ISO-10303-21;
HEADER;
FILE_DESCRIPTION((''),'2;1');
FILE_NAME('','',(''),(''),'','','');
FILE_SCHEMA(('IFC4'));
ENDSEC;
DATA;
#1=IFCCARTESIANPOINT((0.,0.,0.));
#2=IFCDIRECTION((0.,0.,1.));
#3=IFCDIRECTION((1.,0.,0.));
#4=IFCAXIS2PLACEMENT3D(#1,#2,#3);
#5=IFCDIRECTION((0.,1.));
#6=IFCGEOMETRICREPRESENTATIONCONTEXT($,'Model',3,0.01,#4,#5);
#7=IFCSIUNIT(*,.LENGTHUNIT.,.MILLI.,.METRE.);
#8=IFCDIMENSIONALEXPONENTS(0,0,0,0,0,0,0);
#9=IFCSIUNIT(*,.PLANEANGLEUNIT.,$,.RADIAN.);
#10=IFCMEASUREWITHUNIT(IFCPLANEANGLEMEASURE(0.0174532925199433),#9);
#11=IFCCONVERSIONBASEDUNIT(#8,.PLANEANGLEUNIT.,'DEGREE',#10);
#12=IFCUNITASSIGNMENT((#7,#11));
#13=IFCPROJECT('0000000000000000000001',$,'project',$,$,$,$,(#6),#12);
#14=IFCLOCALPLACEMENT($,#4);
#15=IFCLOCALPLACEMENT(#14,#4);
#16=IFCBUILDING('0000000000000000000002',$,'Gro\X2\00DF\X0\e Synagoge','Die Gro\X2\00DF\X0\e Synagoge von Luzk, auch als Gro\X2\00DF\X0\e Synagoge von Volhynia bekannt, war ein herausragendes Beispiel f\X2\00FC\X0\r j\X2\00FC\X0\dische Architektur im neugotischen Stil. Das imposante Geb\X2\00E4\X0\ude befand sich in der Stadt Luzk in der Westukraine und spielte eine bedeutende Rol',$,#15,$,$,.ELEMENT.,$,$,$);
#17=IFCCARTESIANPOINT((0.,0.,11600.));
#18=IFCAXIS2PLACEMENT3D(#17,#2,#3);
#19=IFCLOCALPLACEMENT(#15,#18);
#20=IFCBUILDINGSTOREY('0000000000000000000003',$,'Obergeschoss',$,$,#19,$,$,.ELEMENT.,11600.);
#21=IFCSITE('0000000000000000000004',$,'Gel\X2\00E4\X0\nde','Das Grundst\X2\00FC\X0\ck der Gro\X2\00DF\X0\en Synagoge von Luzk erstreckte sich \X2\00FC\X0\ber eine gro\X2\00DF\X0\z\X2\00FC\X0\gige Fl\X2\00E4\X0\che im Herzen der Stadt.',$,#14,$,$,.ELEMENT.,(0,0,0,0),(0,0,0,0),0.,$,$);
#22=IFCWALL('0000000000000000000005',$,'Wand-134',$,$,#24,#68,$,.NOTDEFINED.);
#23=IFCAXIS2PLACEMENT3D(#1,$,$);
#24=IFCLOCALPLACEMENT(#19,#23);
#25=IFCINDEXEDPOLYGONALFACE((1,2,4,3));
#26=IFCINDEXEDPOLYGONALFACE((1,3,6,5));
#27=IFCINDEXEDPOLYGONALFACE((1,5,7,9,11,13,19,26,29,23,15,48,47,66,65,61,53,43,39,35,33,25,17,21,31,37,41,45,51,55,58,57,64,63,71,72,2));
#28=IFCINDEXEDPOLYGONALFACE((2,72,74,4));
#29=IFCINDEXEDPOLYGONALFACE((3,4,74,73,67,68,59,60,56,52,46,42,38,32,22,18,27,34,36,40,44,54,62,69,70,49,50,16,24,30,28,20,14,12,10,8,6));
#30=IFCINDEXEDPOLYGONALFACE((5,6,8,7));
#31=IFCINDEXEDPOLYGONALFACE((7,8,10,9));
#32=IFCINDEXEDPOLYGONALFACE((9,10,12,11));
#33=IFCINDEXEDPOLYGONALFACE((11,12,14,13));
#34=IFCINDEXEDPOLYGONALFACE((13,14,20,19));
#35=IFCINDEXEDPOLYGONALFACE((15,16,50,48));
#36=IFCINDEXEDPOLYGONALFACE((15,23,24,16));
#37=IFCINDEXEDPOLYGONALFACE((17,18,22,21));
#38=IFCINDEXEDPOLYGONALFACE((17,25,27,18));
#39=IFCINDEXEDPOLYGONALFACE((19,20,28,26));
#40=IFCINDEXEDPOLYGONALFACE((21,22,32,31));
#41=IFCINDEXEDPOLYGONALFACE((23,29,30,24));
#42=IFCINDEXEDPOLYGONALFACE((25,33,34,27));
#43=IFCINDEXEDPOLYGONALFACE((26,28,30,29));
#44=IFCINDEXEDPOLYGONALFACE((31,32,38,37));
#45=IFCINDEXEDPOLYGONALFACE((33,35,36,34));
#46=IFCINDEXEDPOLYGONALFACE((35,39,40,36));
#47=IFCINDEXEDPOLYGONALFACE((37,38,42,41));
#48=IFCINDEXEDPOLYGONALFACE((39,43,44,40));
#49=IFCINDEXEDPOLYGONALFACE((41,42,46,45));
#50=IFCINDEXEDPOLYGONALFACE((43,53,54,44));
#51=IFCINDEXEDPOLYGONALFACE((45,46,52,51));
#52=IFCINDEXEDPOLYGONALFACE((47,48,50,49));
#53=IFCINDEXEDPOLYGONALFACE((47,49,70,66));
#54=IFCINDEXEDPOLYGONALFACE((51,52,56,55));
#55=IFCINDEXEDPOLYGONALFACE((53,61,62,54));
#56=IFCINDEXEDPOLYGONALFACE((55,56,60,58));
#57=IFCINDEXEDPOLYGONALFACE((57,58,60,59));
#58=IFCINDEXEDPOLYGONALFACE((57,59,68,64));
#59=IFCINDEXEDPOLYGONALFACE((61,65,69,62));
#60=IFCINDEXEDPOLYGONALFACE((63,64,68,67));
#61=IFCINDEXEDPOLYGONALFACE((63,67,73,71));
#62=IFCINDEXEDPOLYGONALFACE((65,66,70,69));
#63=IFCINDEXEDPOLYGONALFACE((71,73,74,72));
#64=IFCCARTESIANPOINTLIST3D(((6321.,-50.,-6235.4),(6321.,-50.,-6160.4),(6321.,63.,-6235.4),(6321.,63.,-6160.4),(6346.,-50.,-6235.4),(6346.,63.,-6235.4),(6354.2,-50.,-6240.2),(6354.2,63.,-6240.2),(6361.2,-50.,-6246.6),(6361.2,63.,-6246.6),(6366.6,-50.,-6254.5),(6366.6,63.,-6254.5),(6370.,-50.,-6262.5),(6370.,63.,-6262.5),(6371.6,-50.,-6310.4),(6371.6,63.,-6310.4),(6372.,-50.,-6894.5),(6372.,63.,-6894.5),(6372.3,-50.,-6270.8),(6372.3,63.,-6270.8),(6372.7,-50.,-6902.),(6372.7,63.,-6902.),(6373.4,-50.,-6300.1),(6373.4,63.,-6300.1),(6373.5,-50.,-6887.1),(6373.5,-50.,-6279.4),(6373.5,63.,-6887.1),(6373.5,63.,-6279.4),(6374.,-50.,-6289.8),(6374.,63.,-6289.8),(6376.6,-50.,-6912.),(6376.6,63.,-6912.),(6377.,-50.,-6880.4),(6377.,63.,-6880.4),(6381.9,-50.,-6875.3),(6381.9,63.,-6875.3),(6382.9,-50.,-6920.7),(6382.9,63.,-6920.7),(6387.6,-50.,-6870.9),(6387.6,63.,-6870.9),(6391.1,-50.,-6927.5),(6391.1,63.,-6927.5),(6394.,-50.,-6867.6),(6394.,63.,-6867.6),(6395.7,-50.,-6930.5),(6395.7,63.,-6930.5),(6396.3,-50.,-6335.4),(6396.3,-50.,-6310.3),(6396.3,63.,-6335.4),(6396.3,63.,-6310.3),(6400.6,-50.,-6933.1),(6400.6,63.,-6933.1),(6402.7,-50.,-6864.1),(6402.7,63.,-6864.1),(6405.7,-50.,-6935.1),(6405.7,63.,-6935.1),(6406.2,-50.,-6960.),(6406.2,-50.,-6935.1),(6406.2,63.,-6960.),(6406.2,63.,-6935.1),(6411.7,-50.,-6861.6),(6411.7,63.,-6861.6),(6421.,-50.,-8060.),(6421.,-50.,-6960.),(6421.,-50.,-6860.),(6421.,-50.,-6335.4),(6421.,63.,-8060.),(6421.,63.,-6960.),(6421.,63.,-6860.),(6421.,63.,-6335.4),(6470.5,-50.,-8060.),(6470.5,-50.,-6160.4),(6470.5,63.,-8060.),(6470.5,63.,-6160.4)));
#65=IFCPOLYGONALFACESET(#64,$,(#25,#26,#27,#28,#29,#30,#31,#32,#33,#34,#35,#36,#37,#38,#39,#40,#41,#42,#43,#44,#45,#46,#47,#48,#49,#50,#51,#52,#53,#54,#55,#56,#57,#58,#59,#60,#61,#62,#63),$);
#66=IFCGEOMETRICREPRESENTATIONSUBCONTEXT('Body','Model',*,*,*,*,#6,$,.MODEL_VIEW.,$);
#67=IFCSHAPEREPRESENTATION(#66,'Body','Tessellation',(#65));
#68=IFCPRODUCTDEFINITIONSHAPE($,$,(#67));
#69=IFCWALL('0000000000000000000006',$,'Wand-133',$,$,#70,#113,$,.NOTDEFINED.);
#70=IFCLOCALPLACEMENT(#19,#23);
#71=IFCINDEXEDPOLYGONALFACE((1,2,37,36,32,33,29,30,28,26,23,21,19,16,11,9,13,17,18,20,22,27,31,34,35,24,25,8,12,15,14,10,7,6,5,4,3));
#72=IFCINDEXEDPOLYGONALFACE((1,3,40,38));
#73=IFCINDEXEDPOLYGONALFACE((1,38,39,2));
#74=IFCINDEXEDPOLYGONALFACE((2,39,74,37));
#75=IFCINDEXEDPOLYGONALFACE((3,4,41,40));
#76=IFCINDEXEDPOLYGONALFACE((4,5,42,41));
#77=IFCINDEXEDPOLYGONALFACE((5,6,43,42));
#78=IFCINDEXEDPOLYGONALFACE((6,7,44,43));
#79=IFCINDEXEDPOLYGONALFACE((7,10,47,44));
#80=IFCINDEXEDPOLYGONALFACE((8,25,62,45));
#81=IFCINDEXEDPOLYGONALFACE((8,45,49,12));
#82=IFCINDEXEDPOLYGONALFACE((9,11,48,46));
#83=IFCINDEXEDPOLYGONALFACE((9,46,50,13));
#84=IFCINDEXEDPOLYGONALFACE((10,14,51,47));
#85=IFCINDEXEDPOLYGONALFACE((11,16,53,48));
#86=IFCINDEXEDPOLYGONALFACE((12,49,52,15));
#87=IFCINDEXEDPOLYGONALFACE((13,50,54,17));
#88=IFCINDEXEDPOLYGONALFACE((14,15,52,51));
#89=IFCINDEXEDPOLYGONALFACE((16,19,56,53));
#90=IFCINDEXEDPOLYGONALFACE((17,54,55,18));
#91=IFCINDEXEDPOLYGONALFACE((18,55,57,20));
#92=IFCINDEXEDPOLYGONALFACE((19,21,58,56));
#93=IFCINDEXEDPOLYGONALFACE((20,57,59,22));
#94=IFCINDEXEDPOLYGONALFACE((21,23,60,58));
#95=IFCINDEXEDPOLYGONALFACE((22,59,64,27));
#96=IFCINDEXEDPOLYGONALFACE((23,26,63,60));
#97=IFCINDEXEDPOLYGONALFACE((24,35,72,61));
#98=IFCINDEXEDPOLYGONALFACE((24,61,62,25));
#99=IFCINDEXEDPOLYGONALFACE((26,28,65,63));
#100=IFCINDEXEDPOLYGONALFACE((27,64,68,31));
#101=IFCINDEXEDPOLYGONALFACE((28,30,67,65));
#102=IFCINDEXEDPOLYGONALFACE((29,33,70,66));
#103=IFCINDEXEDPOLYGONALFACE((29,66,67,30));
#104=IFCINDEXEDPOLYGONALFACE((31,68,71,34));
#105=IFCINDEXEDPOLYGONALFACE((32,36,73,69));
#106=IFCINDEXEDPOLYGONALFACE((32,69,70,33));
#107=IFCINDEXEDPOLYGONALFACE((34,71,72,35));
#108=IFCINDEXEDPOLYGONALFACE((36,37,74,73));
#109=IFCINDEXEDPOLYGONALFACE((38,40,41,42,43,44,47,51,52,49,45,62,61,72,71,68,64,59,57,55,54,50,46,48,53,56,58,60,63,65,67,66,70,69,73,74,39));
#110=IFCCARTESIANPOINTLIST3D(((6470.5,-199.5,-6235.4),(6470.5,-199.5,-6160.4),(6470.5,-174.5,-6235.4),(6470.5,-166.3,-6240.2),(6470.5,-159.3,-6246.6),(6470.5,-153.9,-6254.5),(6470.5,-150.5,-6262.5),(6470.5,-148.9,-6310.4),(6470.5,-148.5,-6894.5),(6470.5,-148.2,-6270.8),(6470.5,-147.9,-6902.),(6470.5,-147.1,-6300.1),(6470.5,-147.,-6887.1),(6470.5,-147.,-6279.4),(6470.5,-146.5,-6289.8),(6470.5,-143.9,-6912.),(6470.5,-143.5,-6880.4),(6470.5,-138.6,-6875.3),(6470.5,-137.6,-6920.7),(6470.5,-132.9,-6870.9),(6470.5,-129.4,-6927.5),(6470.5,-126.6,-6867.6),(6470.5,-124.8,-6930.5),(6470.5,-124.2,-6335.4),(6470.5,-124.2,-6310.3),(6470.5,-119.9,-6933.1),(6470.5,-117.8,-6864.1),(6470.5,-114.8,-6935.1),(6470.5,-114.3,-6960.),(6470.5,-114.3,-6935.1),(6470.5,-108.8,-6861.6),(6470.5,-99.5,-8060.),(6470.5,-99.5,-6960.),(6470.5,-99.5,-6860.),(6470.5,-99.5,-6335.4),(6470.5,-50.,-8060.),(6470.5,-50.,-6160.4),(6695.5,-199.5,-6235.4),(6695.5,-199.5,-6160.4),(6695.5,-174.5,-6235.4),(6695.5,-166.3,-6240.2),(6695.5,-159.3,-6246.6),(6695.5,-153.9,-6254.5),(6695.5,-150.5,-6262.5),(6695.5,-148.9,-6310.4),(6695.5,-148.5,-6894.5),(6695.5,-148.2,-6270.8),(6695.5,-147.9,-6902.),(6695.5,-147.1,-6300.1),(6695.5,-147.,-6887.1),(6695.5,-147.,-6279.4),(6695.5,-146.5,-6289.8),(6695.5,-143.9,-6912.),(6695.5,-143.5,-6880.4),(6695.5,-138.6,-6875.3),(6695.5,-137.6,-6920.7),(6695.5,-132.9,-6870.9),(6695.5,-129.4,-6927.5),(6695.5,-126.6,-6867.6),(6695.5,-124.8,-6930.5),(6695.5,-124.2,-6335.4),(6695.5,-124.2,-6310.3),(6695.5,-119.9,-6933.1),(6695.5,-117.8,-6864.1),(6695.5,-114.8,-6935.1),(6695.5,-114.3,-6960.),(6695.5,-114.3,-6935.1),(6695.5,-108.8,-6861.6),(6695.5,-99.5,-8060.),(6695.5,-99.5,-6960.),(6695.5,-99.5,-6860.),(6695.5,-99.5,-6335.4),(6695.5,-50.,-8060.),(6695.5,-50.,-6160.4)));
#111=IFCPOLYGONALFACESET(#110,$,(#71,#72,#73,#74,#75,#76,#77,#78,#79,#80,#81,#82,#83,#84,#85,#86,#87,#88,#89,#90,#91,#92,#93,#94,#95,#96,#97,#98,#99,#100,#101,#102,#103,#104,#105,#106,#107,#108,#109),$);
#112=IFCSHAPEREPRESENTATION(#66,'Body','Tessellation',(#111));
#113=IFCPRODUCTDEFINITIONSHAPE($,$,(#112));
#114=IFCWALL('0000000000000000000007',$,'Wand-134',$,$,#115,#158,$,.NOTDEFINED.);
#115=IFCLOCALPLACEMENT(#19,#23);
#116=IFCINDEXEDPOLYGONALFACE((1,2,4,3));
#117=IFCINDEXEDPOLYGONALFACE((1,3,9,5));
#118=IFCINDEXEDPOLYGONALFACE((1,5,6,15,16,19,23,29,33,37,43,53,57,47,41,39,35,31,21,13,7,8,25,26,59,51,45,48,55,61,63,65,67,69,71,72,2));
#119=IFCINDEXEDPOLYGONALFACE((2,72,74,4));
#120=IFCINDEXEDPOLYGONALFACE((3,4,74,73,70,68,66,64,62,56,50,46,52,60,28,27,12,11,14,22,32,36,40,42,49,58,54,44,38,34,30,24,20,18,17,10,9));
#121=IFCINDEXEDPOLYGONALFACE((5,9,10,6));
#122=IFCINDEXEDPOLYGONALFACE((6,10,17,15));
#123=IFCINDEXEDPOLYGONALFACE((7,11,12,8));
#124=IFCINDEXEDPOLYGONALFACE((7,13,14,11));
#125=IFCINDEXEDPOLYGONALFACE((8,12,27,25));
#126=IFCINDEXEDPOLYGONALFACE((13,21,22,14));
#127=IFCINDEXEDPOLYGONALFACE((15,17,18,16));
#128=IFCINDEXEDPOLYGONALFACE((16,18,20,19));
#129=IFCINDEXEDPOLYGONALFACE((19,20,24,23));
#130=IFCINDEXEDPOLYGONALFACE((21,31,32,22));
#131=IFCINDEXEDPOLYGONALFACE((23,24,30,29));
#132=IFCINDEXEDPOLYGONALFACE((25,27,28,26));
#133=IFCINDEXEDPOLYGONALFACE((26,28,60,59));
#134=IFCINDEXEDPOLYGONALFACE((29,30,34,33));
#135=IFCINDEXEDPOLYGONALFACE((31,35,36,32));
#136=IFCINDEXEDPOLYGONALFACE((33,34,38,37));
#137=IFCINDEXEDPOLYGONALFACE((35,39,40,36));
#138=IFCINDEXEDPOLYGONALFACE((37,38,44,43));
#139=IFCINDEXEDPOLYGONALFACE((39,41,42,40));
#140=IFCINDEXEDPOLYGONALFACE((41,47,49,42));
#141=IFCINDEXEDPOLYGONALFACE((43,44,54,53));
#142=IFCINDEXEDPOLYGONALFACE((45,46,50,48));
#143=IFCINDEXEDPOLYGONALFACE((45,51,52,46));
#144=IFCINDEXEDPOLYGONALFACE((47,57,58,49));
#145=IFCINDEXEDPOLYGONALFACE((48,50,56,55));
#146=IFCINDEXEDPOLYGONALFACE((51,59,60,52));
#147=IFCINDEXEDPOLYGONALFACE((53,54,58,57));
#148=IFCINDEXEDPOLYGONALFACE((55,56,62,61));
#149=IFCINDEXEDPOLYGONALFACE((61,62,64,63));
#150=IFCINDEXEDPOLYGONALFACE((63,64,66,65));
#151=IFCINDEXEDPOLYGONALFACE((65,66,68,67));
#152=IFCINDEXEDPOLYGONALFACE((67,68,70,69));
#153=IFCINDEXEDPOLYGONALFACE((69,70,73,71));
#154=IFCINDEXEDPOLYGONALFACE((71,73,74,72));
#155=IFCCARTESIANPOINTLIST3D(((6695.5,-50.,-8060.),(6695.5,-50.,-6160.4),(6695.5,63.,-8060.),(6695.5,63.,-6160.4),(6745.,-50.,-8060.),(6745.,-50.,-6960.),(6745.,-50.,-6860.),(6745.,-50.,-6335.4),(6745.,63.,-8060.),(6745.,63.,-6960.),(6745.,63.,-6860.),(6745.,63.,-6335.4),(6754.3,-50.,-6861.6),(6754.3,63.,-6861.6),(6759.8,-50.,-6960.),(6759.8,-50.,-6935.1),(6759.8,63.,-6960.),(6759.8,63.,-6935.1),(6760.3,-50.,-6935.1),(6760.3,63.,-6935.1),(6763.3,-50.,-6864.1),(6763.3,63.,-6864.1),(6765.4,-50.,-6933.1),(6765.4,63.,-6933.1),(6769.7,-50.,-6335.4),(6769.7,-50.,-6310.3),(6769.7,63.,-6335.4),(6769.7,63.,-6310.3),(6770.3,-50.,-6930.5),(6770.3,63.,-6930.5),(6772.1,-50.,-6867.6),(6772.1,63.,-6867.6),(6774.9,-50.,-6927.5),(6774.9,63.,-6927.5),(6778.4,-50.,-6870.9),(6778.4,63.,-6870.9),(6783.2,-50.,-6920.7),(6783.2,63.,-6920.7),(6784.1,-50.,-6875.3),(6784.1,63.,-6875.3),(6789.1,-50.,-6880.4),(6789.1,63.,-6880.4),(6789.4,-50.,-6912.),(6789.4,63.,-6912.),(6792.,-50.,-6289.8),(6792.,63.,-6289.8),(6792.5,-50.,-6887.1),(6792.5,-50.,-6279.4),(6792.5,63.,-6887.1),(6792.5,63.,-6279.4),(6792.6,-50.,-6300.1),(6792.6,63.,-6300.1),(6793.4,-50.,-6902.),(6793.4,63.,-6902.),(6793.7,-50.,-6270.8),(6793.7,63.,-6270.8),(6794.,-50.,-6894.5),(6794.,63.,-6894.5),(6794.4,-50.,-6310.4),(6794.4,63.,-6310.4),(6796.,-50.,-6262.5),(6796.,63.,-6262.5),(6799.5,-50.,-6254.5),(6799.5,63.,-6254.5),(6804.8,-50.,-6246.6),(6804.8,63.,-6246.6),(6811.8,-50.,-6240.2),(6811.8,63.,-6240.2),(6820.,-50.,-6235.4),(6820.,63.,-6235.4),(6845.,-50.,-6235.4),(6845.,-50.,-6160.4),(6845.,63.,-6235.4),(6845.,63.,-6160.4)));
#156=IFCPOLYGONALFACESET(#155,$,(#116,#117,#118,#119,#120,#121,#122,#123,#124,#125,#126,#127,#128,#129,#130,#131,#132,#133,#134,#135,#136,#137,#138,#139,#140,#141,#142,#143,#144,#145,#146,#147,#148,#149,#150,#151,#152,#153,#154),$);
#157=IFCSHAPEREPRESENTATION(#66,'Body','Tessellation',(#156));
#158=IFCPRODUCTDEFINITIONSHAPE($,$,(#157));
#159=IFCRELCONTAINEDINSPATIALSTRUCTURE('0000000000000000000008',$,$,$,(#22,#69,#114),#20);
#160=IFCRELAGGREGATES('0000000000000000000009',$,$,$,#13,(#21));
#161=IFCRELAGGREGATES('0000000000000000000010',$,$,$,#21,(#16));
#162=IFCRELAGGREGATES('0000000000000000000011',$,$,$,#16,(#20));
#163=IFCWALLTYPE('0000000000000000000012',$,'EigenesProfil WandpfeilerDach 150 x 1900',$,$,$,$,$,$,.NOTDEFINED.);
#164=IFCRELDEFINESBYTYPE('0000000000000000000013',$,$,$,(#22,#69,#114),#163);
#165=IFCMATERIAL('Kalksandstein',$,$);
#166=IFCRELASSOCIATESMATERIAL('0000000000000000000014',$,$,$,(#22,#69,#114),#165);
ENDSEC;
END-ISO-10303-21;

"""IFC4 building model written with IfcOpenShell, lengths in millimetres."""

from ifc_helpers import new_model, entity, si_unit, converted_unit, direction, frame, origin_with_axes, place, context, subcontext, project, spatial, line, arc, indexed_curve, outline, extrude, material, material_profile, profile_set, type_object, element, save


model = new_model("IFC4")

# Units and contexts
model_context = context("Model", 3, precision=0.01, world=origin_with_axes(), true_north=direction((0.0, 1.0)))
body_context = subcontext(model_context, "Body", "Model", "MODEL_VIEW")
ifc_project = project(units=[si_unit("LENGTHUNIT", "METRE", prefix="MILLI"), converted_unit("PLANEANGLEUNIT", "DEGREE", entity("IfcPlaneAngleMeasure", 0.0174532925199433), si_unit("PLANEANGLEUNIT", "RADIAN"), dimensions=[0, 0, 0, 0, 0, 0, 0])], contexts=[model_context])

# Site, building, storey
site_placement = place(None, origin_with_axes())
site = spatial("IfcSite", under=ifc_project, at=site_placement, Name="Gelände", Description="Das Grundstück der Großen Synagoge von Luzk erstreckte sich über eine großzügige Fläche im Herzen der Stadt.", CompositionType="ELEMENT", RefLatitude=(0, 0, 0, 0), RefLongitude=(0, 0, 0, 0), RefElevation=0.0)
building_placement = place(site_placement, origin_with_axes())
building = spatial("IfcBuilding", under=site, at=building_placement, Name="Große Synagoge", Description="Die Große Synagoge von Luzk, auch als Große Synagoge von Volhynia bekannt, war ein herausragendes Beispiel für jüdische Architektur im neugotischen Stil. Das imposante Gebäude befand sich in der Stadt Luzk in der Westukraine und spielte eine bedeutende Rol", CompositionType="ELEMENT")
storey_placement = place(building_placement, frame((0.0, 0.0, 11600.0), z_axis=(0.0, 0.0, 1.0), x_axis=(1.0, 0.0, 0.0)))
storey = spatial("IfcBuildingStorey", under=building, at=storey_placement, Name="Obergeschoss", CompositionType="ELEMENT", Elevation=11600.0)

# Walls
ifc_material_1 = material(Name="Kalksandstein")
ifc_material_profile = material_profile(ifc_material_1, outline(indexed_curve([(74.2, 1749.6), (98.9, 1749.6), (96.7, 1765.0), (97.0, 1780.5), (99.2, 1793.4), (103.9, 1805.5), (112.6, 1816.7), (124.5, 1824.6), (149.5, 1824.6), (149.5, 1899.6), (0.0, 1899.6), (0.0, 0.0), (49.5, 0.0), (49.5, 1100.0), (64.3, 1100.0), (64.3, 1124.9), (64.8, 1124.9), (72.4, 1128.1), (79.4, 1132.4), (91.1, 1143.4), (97.9, 1157.9), (98.0, 1169.2), (93.5, 1179.5), (85.8, 1187.0), (76.6, 1192.3), (63.3, 1197.2), (49.5, 1200.0), (49.5, 1724.6), (74.2, 1724.6)], segments=[line(1, 2), arc(2, 3, 4), arc(4, 5, 6), arc(6, 7, 8), line(8, 9, 10, 11, 12, 13, 14, 15, 16, 17), arc(17, 18, 19), arc(19, 20, 21), arc(21, 22, 23), arc(23, 24, 25), arc(25, 26, 27), line(27, 28, 29, 1)])), Name="Kalksandstein")
ifc_profile_set = profile_set([ifc_material_profile], Name="EigenesProfil WandpfeilerDach")
wall_type_1 = type_object("IfcWallType", Name="EigenesProfil WandpfeilerDach 150 x 1900", PredefinedType="NOTDEFINED")
for number, where, z_axis, x_axis, name in (
    (1, (6470.5, -50.0, -8060.0), (0.0, 0.0, 1.0), (0.0, 1.0, 0.0), "Wand-134"),
):
    element("IfcWall", number, at=place(storey_placement, frame(where, z_axis=z_axis, x_axis=x_axis)), inside=storey, type_object=wall_type_1, material=ifc_profile_set, Name=name, PredefinedType="NOTDEFINED", context=body_context, shape_type="SweptSolid", body=[
        extrude(outline(indexed_curve([(74.2, 1749.6), (98.9, 1749.6), (96.7, 1765.0), (97.0, 1780.5), (99.2, 1793.4), (103.9, 1805.5), (112.6, 1816.7), (124.5, 1824.6), (149.5, 1824.6), (149.5, 1899.6), (0.0, 1899.6), (0.0, 0.0), (49.5, 0.0), (49.5, 1100.0), (64.3, 1100.0), (64.3, 1124.9), (64.8, 1124.9), (72.4, 1128.1), (79.4, 1132.4), (91.1, 1143.4), (97.9, 1157.9), (98.0, 1169.2), (93.5, 1179.5), (85.8, 1187.0), (76.6, 1192.3), (63.3, 1197.2), (49.5, 1200.0), (49.5, 1724.6), (74.2, 1724.6)], segments=[line(1, 2), arc(2, 3, 4), arc(4, 5, 6), arc(6, 7, 8), line(8, 9, 10, 11, 12, 13, 14, 15, 16, 17), arc(17, 18, 19), arc(19, 20, 21), arc(21, 22, 23), arc(23, 24, 25), arc(25, 26, 27), line(27, 28, 29, 1)])), frame((0.0, 0.0, 0.0), z_axis=(1.0, 0.0, 0.0), x_axis=(0.0, 1.0, 0.0)), (0.0, 0.0, 1.0), 113.0),
    ])
wall_1_placement = place(storey_placement, frame((6470.5, -50.0, -8060.0), z_axis=(0.0, 0.0, 1.0), x_axis=(1.0, 0.0, 0.0)))
element("IfcWall", 2, at=wall_1_placement, inside=storey, type_object=wall_type_1, material=ifc_profile_set, Name="Wand-133", PredefinedType="NOTDEFINED", context=body_context, shape_type="SweptSolid", body=[
    extrude(outline(indexed_curve([(74.2, 1749.6), (98.9, 1749.6), (96.7, 1765.0), (97.0, 1780.5), (99.2, 1793.4), (103.9, 1805.5), (112.6, 1816.7), (124.5, 1824.6), (149.5, 1824.6), (149.5, 1899.6), (0.0, 1899.6), (0.0, 0.0), (49.5, 0.0), (49.5, 1100.0), (64.3, 1100.0), (64.3, 1124.9), (64.8, 1124.9), (72.4, 1128.1), (79.4, 1132.4), (91.1, 1143.4), (97.9, 1157.9), (98.0, 1169.2), (93.5, 1179.5), (85.8, 1187.0), (76.6, 1192.3), (63.3, 1197.2), (49.5, 1200.0), (49.5, 1724.6), (74.2, 1724.6)], segments=[line(1, 2), arc(2, 3, 4), arc(4, 5, 6), arc(6, 7, 8), line(8, 9, 10, 11, 12, 13, 14, 15, 16, 17), arc(17, 18, 19), arc(19, 20, 21), arc(21, 22, 23), arc(23, 24, 25), arc(25, 26, 27), line(27, 28, 29, 1)])), frame((0.0, 0.0, 0.0), z_axis=(-1.0, 0.0, 0.0), x_axis=(0.0, -1.0, 0.0)), (0.0, 0.0, -1.0), 225.0),
])
wall_2_placement = place(storey_placement, frame((6695.5, -50.0, -8060.0), z_axis=(0.0, 0.0, 1.0), x_axis=(0.0, 1.0, 0.0)))
element("IfcWall", 3, at=wall_2_placement, inside=storey, type_object=wall_type_1, material=ifc_profile_set, Name="Wand-134", PredefinedType="NOTDEFINED", context=body_context, shape_type="SweptSolid", body=[
    extrude(outline(indexed_curve([(74.2, 1749.6), (98.9, 1749.6), (96.7, 1765.0), (97.0, 1780.5), (99.2, 1793.4), (103.9, 1805.5), (112.6, 1816.7), (124.5, 1824.6), (149.5, 1824.6), (149.5, 1899.6), (0.0, 1899.6), (0.0, 0.0), (49.5, 0.0), (49.5, 1100.0), (64.3, 1100.0), (64.3, 1124.9), (64.8, 1124.9), (72.4, 1128.1), (79.4, 1132.4), (91.1, 1143.4), (97.9, 1157.9), (98.0, 1169.2), (93.5, 1179.5), (85.8, 1187.0), (76.6, 1192.3), (63.3, 1197.2), (49.5, 1200.0), (49.5, 1724.6), (74.2, 1724.6)], segments=[line(1, 2), arc(2, 3, 4), arc(4, 5, 6), arc(6, 7, 8), line(8, 9, 10, 11, 12, 13, 14, 15, 16, 17), arc(17, 18, 19), arc(19, 20, 21), arc(21, 22, 23), arc(23, 24, 25), arc(25, 26, 27), line(27, 28, 29, 1)])), frame((0.0, 0.0, 0.0), z_axis=(-1.0, 0.0, 0.0), x_axis=(0.0, -1.0, 0.0)), (0.0, 0.0, -1.0), 113.0),
])

save(model, "model.ifc")
